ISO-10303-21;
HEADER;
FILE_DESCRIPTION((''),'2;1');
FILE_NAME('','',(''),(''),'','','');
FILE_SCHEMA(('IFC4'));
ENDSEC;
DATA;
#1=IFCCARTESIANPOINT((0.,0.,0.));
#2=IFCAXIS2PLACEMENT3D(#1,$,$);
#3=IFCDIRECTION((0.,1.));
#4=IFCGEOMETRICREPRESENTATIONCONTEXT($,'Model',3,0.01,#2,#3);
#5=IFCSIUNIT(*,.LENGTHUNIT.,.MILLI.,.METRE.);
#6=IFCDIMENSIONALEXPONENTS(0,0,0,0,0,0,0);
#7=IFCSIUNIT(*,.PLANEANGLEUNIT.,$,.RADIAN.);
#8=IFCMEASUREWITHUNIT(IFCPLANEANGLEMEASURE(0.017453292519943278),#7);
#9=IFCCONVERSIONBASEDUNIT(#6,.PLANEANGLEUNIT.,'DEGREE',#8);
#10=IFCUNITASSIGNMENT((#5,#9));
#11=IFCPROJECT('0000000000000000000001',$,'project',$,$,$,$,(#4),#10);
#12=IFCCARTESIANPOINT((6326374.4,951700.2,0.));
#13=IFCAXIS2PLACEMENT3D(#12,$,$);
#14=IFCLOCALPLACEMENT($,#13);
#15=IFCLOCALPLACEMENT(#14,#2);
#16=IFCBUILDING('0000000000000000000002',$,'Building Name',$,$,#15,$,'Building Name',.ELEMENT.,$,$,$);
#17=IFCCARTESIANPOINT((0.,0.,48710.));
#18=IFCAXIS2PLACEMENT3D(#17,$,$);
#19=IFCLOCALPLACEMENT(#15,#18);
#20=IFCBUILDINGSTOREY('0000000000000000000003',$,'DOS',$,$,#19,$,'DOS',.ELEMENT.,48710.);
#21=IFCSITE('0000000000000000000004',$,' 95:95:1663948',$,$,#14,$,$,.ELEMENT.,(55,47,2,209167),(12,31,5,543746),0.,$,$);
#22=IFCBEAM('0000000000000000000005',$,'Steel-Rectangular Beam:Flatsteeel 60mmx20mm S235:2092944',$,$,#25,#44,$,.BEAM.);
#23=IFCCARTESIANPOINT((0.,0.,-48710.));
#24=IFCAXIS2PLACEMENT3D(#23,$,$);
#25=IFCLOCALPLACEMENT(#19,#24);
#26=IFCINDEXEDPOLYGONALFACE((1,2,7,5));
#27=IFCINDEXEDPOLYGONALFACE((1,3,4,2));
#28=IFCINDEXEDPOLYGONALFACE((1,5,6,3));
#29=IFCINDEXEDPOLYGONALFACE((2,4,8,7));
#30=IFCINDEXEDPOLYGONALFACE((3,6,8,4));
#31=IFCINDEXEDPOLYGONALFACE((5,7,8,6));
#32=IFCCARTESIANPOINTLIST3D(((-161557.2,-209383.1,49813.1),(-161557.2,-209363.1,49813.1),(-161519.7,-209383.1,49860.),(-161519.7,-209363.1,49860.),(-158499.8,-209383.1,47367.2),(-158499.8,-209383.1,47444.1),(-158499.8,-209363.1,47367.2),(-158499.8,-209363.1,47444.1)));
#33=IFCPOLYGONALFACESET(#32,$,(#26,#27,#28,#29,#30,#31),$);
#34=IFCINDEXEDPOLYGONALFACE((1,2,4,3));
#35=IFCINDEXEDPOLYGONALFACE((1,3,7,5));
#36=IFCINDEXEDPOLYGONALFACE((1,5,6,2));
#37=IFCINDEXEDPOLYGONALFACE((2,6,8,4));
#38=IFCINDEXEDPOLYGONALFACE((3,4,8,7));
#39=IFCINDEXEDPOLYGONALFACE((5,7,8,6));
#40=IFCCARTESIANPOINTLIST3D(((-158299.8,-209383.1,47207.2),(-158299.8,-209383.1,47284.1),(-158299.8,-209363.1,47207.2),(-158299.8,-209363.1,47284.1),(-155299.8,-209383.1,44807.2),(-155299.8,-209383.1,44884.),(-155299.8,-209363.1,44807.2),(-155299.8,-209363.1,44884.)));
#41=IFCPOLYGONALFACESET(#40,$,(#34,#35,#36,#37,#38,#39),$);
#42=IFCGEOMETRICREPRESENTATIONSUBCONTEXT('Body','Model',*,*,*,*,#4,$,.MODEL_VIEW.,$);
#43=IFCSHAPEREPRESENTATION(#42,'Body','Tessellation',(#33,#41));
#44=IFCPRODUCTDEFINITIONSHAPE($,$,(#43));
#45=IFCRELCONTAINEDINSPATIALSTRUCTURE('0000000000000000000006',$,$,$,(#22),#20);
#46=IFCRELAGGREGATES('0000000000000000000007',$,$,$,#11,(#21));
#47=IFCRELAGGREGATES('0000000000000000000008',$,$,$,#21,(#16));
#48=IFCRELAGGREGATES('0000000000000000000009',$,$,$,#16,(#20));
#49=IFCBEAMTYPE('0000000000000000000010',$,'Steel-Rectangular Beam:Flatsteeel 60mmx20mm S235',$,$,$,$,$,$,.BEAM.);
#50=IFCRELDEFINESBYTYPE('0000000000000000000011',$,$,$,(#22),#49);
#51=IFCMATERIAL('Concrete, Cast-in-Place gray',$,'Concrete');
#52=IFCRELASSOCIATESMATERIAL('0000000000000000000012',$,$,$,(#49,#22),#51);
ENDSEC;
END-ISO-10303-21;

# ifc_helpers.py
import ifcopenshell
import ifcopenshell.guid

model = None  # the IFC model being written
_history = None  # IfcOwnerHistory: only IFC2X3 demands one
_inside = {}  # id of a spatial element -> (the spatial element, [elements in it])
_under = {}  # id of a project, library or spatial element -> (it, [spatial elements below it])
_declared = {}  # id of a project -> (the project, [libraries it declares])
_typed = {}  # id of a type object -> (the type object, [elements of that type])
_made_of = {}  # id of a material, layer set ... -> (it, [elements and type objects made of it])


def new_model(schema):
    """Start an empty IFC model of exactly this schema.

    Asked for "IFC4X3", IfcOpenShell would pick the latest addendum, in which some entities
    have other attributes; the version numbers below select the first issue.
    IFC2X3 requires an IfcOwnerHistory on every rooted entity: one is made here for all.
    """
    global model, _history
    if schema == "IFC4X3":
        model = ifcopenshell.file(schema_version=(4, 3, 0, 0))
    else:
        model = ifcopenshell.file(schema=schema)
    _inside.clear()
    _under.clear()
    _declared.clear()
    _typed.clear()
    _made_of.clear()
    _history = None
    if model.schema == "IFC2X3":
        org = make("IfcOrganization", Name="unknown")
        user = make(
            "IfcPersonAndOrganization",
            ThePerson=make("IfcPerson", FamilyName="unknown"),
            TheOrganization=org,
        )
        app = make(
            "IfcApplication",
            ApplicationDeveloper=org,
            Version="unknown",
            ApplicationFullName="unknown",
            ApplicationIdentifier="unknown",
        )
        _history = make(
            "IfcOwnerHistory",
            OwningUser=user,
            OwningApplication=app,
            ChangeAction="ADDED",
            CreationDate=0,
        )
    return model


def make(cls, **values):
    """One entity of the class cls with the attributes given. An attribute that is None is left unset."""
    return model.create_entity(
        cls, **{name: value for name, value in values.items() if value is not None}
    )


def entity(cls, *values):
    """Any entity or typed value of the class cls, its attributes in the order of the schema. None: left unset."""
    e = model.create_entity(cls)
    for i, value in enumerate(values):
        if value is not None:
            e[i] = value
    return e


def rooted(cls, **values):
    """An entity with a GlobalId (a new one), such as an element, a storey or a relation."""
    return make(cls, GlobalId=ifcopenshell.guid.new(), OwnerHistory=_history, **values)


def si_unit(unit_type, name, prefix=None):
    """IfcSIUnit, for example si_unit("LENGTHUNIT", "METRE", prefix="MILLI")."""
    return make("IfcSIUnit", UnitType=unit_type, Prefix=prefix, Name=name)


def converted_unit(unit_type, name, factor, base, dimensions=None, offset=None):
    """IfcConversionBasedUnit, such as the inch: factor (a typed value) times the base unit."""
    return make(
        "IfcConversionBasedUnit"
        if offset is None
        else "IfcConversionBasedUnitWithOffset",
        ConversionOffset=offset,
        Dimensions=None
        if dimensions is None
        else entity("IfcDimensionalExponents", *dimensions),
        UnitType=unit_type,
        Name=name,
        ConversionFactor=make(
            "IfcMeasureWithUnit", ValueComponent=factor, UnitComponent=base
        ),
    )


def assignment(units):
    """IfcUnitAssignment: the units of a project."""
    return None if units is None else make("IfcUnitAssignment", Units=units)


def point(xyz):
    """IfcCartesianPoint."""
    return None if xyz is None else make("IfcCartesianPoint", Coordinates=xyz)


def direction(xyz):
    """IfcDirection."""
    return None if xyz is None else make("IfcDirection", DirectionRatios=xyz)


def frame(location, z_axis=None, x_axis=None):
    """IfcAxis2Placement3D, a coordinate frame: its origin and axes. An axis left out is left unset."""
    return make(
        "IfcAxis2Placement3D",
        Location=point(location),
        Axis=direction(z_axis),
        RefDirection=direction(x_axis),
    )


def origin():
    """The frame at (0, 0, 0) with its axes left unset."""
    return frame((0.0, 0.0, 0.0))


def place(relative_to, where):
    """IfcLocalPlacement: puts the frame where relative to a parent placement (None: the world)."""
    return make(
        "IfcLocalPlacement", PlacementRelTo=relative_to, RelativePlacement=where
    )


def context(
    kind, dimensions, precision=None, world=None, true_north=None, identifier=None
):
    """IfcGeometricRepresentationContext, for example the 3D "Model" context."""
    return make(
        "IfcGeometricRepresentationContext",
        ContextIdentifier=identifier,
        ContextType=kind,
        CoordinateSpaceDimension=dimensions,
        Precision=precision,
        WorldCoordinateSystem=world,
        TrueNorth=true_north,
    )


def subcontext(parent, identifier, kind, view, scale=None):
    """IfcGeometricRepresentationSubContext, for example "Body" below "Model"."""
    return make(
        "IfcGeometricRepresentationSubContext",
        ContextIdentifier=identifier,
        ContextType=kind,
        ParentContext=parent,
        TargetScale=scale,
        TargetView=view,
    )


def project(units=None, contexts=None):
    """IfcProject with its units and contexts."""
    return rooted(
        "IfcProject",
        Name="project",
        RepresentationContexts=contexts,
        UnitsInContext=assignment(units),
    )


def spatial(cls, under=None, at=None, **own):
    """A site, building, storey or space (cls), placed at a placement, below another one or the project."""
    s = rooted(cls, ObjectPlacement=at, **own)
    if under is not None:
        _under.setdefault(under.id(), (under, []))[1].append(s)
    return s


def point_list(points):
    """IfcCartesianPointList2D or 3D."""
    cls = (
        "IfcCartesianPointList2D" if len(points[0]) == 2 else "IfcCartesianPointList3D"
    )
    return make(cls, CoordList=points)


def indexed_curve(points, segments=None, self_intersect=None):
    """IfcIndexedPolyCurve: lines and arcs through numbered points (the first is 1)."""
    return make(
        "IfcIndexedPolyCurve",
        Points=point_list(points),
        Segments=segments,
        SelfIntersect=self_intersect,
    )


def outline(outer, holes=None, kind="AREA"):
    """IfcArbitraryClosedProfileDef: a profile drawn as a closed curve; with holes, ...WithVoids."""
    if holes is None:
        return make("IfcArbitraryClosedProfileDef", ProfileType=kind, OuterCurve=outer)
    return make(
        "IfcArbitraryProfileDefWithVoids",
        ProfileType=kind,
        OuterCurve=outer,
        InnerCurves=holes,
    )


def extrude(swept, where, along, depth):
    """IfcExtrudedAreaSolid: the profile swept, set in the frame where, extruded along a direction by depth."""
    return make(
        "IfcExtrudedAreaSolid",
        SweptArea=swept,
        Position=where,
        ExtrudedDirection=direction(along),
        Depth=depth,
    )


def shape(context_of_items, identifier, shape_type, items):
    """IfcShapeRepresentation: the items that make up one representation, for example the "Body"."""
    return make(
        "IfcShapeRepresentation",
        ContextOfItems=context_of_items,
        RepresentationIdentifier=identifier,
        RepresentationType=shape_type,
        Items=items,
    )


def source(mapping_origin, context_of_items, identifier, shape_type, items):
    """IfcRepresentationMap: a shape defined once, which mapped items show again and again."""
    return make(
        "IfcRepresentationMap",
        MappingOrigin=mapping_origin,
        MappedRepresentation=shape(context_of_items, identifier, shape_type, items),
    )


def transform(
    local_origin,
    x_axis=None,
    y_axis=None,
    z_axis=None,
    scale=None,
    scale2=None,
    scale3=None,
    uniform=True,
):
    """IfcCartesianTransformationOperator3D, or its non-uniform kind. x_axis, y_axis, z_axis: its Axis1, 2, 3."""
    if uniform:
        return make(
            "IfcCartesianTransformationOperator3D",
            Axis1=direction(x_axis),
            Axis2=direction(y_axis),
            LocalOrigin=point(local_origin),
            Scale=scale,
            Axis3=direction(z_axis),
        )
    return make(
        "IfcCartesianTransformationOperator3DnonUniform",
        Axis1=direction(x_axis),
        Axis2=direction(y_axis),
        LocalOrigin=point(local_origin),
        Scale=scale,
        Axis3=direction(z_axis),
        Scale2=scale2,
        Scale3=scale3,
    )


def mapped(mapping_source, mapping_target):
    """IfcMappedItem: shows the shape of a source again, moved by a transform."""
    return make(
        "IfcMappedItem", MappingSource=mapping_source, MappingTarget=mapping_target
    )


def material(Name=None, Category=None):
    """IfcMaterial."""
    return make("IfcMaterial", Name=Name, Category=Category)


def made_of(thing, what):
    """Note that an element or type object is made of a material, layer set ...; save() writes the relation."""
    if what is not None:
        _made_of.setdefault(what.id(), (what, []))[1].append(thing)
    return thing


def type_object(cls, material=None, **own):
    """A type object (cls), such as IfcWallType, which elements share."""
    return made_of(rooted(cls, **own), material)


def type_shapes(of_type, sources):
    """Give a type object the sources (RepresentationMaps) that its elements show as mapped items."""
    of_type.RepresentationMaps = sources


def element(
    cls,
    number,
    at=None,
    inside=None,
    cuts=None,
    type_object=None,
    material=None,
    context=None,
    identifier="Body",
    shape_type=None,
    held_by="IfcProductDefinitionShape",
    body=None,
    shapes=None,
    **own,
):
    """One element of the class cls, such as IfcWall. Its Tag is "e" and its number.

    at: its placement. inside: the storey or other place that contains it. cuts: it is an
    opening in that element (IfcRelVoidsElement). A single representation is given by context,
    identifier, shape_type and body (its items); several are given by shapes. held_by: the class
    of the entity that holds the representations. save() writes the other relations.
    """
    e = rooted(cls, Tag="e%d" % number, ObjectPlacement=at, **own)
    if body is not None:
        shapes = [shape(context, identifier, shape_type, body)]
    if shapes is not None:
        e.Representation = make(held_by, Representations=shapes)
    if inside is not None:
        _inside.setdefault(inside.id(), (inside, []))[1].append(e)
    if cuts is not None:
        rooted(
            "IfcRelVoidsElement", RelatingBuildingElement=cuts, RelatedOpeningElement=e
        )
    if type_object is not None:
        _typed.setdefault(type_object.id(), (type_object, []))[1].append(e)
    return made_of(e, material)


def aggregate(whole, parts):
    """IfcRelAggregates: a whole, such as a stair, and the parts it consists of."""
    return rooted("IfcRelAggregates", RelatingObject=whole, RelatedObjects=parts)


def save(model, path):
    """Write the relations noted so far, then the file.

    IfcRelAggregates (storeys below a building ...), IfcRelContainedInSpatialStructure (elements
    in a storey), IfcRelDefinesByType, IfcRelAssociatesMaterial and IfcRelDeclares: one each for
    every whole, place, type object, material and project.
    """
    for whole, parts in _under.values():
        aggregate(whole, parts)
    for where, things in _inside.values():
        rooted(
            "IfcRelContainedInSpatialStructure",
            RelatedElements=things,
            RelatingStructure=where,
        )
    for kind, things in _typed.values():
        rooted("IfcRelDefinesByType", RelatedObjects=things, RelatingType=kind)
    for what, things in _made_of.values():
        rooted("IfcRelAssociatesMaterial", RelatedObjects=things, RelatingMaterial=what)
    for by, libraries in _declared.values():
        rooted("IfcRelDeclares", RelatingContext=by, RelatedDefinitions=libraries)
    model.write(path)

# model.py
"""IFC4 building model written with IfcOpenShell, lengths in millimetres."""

from ifc_helpers import new_model, entity, si_unit, converted_unit, direction, frame, origin, place, context, subcontext, project, spatial, indexed_curve, outline, extrude, source, transform, mapped, material, type_object, type_shapes, element, save


model = new_model("IFC4")

# Units and contexts
model_context = context("Model", 3, precision=0.01, world=origin(), true_north=direction((0.0, 1.0)))
body_context = subcontext(model_context, "Body", "Model", "MODEL_VIEW")
ifc_project = project(units=[si_unit("LENGTHUNIT", "METRE", prefix="MILLI"), converted_unit("PLANEANGLEUNIT", "DEGREE", entity("IfcPlaneAngleMeasure", 0.017453292519943278), si_unit("PLANEANGLEUNIT", "RADIAN"), dimensions=[0, 0, 0, 0, 0, 0, 0])], contexts=[model_context])

# Site, building, storey
site_placement = place(None, frame((6326374.4, 951700.2, 0.0)))
site = spatial("IfcSite", under=ifc_project, at=site_placement, Name=" 95:95:1663948", CompositionType="ELEMENT", RefLatitude=(55, 47, 2, 209167), RefLongitude=(12, 31, 5, 543746), RefElevation=0.0)
building_placement = place(site_placement, origin())
building = spatial("IfcBuilding", under=site, at=building_placement, Name="Building Name", LongName="Building Name", CompositionType="ELEMENT")
storey_placement = place(building_placement, frame((0.0, 0.0, 48710.0)))
storey = spatial("IfcBuildingStorey", under=building, at=storey_placement, Name="DOS", LongName="DOS", CompositionType="ELEMENT", Elevation=48710.0)

# Beam
ifc_material = material(Name="Concrete, Cast-in-Place gray", Category="Concrete")
beam_type_1 = type_object("IfcBeamType", Name="Steel-Rectangular Beam:Flatsteeel 60mmx20mm S235", PredefinedType="BEAM", material=ifc_material)
shared_shape_1 = source(origin(), body_context, "Body", "SweptSolid", [
    extrude(outline(indexed_curve([(-1945.7, -30.0), (1921.7, -30.0), (1969.7, 30.0), (-1945.7, 30.0), (-1945.7, -30.0)], self_intersect=False)), frame((-160019.1, -209383.1, 48621.1), z_axis=(0.0, 1.0, 0.0), x_axis=(0.780862, 0.0, -0.624704)), (0.0, 0.0, 1.0), 20.0),
    extrude(outline(indexed_curve([(-1945.0, -30.0), (1897.0, -30.0), (1945.0, 30.0), (-1897.0, 30.0), (-1945.0, -30.0)], self_intersect=False)), frame((-156799.8, -209383.1, 46045.6), z_axis=(0.0, 1.0, 0.0), x_axis=(-0.780862, 0.0, 0.624704)), (0.0, 0.0, 1.0), 20.0),
])
type_shapes(beam_type_1, [shared_shape_1])
beam_1_placement = place(storey_placement, frame((0.0, 0.0, -48710.0)))
element("IfcBeam", 1, at=beam_1_placement, inside=storey, type_object=beam_type_1, material=ifc_material, Name="Steel-Rectangular Beam:Flatsteeel 60mmx20mm S235:2092944", PredefinedType="BEAM", context=body_context, shape_type="MappedRepresentation", body=[
    mapped(shared_shape_1, transform((0.0, 0.0, 0.0), scale=1.0)),
])

save(model, "model.ifc")
